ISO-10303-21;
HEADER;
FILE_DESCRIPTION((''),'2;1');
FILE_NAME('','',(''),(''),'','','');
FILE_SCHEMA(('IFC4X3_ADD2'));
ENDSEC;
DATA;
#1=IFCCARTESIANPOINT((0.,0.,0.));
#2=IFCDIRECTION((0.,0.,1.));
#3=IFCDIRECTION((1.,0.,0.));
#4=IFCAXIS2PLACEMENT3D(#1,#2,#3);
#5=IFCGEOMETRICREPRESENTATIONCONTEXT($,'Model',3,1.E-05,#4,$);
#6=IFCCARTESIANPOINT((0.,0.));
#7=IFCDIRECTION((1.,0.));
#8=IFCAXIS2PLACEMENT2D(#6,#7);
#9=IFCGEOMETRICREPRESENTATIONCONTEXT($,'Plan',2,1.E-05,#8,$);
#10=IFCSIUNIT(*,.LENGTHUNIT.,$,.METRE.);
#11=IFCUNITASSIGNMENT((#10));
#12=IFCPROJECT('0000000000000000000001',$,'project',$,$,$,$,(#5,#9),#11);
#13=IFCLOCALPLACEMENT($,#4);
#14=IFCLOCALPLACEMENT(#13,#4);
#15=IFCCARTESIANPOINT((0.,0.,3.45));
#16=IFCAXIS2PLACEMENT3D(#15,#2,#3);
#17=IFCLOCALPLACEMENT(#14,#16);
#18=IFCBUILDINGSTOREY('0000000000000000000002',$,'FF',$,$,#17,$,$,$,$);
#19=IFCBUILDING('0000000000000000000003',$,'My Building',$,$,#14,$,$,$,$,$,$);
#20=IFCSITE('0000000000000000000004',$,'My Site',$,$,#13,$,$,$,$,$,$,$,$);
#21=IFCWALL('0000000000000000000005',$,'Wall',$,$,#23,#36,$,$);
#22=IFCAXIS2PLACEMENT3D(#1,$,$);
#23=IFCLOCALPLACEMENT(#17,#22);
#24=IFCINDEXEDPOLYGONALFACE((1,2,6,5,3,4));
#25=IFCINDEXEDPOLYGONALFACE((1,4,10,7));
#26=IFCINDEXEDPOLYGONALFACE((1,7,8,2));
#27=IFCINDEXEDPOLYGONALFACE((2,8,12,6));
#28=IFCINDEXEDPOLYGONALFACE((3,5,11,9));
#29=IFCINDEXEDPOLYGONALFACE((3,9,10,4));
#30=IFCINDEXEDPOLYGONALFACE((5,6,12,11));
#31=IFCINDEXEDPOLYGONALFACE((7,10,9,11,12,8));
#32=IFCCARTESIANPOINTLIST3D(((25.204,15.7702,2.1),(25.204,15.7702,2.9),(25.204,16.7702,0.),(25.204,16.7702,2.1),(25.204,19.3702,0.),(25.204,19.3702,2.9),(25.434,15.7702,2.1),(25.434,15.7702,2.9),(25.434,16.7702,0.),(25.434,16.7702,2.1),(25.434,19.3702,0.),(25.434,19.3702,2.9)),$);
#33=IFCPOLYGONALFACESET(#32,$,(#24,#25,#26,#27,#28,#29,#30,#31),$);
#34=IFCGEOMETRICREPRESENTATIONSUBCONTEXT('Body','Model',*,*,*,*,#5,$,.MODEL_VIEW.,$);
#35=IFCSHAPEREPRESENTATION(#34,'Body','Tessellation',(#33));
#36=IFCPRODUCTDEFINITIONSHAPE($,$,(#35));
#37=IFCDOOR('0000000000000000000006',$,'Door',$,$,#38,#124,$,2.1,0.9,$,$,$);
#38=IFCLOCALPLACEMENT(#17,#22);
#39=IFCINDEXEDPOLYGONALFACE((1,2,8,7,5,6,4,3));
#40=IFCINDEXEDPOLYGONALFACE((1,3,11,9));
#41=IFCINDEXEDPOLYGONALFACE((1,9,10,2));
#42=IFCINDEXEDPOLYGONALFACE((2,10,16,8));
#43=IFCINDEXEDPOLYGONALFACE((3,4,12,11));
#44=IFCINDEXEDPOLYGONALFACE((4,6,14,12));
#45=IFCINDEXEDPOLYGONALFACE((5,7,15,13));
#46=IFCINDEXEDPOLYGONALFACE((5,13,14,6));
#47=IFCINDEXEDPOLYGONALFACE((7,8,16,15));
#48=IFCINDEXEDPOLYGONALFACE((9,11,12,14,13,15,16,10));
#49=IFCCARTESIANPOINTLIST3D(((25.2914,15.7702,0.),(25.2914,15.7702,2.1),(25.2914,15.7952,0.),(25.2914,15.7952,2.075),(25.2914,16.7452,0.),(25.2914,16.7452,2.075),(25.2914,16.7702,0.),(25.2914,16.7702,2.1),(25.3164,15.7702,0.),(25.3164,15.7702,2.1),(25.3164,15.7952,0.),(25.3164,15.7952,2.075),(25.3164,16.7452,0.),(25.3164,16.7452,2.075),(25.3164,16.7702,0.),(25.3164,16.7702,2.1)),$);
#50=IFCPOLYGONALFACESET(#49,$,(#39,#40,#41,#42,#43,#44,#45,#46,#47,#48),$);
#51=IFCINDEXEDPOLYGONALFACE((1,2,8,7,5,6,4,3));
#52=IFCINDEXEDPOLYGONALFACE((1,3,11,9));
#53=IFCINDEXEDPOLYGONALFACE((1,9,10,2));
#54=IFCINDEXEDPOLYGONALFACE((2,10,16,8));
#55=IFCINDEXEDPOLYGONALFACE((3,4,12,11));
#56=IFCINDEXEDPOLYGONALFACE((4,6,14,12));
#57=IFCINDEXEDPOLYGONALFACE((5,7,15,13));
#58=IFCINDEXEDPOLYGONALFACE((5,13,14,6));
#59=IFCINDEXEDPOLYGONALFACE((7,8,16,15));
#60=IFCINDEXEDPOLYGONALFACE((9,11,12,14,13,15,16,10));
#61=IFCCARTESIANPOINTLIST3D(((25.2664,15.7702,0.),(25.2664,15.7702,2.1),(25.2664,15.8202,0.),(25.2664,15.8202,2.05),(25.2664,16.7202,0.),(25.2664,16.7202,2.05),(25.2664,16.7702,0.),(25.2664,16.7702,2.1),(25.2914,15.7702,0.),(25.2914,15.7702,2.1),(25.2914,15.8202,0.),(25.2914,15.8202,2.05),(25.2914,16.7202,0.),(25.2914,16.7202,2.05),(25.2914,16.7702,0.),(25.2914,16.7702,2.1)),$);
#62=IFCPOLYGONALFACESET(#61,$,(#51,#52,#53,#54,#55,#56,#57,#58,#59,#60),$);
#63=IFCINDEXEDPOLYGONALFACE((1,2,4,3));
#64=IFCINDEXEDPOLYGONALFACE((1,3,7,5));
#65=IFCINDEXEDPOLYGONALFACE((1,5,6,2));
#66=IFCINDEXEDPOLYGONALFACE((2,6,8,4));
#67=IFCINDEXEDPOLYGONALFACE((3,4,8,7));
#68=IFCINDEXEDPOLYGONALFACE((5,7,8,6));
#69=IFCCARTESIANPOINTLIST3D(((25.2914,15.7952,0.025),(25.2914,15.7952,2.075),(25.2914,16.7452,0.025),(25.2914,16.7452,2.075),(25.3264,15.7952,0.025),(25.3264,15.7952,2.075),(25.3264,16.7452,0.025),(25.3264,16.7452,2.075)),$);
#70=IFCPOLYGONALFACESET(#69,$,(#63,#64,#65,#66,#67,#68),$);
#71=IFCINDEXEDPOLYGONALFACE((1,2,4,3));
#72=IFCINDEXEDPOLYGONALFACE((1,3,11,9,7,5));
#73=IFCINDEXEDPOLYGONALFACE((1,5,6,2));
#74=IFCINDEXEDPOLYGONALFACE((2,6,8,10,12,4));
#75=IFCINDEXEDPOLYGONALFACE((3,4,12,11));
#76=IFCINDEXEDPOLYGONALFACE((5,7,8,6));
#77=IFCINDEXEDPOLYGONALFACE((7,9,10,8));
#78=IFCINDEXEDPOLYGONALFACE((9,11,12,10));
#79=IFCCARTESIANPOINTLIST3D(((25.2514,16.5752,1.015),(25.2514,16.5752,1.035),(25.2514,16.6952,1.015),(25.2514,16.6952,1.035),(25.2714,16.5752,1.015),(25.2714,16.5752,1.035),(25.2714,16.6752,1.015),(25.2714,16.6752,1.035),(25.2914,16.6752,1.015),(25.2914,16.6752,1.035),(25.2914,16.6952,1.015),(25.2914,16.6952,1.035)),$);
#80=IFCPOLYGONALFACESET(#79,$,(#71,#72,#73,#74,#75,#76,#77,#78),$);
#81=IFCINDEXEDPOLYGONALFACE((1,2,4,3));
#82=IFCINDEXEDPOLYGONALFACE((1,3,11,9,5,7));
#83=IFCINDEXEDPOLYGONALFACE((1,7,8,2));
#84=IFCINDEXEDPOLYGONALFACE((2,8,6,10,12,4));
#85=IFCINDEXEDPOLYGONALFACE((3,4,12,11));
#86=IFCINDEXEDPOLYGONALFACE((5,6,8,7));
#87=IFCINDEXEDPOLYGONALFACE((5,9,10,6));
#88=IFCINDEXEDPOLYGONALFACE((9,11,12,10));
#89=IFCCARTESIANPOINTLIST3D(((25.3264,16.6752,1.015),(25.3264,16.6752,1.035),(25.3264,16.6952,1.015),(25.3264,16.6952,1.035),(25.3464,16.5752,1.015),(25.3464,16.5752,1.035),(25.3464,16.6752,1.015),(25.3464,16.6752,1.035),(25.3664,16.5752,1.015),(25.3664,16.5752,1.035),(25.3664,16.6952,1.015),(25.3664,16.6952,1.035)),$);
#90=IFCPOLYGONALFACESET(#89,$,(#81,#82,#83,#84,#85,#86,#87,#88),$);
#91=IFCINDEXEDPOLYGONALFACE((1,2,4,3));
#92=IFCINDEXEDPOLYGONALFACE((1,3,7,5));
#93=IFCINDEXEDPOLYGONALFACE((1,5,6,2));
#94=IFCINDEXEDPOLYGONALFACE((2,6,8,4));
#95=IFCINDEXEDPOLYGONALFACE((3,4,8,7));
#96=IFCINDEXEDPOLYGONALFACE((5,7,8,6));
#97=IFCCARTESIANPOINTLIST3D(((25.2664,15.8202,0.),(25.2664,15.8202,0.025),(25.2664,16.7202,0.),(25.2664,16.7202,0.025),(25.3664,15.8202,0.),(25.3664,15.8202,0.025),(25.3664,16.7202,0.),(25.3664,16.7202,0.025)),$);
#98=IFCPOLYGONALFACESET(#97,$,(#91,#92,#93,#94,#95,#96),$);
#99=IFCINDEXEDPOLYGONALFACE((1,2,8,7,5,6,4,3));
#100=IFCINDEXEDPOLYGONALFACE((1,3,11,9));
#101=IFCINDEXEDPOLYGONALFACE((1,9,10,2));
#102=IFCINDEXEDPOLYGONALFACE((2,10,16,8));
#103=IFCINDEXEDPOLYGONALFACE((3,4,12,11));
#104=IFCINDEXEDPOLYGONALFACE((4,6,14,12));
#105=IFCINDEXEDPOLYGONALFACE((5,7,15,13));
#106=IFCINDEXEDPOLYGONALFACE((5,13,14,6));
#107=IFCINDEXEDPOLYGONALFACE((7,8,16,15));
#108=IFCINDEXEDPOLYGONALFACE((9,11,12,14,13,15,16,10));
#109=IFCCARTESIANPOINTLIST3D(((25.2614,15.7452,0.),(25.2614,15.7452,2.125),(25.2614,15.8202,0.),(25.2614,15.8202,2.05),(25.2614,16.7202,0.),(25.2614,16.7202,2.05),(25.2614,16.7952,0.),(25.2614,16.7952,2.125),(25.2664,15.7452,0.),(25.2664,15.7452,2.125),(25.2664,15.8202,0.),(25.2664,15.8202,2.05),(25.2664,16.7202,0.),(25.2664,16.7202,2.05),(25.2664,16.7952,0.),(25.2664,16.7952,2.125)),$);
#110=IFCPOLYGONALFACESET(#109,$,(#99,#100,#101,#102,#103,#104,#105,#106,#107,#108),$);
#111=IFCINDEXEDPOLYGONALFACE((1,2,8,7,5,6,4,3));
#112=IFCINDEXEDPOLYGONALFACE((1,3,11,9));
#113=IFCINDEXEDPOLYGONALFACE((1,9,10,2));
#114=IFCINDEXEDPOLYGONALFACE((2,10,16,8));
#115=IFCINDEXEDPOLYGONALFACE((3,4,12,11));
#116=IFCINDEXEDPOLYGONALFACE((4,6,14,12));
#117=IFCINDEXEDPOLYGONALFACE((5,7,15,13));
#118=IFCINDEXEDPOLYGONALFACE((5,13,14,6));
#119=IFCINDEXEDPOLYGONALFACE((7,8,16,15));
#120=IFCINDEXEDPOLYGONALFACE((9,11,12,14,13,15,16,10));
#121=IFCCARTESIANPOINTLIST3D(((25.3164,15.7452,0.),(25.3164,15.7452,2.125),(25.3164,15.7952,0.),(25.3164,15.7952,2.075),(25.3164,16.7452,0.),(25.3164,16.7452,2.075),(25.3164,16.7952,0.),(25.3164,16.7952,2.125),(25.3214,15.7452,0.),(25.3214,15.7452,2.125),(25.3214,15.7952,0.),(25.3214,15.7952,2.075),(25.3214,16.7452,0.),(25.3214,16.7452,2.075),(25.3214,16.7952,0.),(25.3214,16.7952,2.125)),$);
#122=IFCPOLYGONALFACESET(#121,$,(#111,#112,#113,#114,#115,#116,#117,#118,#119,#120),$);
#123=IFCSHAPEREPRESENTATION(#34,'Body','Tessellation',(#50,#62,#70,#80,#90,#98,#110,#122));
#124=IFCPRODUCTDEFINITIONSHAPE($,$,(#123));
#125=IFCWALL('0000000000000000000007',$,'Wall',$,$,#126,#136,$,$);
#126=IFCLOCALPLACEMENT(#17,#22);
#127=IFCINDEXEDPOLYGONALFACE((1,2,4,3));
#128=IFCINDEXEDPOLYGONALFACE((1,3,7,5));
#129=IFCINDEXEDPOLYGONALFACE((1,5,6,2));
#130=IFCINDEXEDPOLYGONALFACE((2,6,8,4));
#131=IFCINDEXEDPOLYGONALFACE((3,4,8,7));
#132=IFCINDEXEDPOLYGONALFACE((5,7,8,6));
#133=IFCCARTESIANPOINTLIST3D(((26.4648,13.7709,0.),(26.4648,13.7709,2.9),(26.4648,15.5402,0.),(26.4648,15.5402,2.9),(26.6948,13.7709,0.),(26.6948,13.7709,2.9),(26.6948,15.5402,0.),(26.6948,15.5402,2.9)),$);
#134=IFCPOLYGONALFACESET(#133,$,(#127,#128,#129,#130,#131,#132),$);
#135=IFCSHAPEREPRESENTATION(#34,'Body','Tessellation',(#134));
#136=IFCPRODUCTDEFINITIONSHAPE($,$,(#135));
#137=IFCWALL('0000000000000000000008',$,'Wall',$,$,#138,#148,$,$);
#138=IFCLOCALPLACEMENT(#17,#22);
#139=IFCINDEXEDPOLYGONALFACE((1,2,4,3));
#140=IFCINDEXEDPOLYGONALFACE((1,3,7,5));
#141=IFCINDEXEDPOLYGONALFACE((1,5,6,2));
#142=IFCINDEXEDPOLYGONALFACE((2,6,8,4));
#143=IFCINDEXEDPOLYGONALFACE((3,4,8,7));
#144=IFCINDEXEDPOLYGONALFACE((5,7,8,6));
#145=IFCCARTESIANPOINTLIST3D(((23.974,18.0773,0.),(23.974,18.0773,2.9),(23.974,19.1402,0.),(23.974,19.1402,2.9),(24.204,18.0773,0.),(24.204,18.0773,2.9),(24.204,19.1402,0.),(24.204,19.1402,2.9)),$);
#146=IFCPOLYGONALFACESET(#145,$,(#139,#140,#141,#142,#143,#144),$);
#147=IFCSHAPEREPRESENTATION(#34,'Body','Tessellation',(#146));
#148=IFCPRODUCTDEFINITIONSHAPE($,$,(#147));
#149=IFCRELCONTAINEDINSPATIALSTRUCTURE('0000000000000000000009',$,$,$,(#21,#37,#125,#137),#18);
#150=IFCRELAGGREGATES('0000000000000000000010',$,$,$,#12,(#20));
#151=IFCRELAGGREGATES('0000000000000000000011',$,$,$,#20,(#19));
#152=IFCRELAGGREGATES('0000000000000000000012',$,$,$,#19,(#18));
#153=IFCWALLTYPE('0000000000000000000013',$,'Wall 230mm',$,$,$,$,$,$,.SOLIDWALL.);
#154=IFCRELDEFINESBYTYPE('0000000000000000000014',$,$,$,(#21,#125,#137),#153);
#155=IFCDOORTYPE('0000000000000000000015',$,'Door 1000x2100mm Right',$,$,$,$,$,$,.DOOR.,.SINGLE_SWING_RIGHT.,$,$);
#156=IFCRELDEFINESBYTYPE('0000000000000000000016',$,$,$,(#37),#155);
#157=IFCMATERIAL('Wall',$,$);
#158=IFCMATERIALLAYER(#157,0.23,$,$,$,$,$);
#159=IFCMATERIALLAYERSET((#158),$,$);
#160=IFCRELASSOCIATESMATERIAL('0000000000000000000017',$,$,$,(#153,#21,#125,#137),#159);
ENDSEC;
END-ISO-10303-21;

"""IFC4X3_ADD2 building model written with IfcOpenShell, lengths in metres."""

from ifc_helpers import new_model, entity, si_unit, frame, origin_with_axes, origin_2d_with_axis, place, context, subcontext, project, spatial, line, indexed_curve, outline, extrude, shape, source, transform, mapped, material, layer, layer_set, layer_usage, type_object, type_shapes, element, fill, save


model = new_model("IFC4X3_ADD2")

# Units and contexts
model_context = context("Model", 3, precision=1e-05, world=origin_with_axes())
plan_context = context("Plan", 2, precision=1e-05, world=origin_2d_with_axis())
body_context_1 = subcontext(model_context, "Body", "Model", "MODEL_VIEW")
body_context_2 = subcontext(plan_context, "Body", "Plan", "PLAN_VIEW")
ifc_project = project(units=[si_unit("LENGTHUNIT", "METRE")], contexts=[model_context, plan_context])

# Site, building, storey
site_placement = place(None, origin_with_axes())
site = spatial("IfcSite", under=ifc_project, at=site_placement, Name="My Site")
building_placement = place(site_placement, origin_with_axes())
building = spatial("IfcBuilding", under=site, at=building_placement, Name="My Building")
storey_placement = place(building_placement, frame((0.0, 0.0, 3.45), z_axis=(0.0, 0.0, 1.0), x_axis=(1.0, 0.0, 0.0)))
storey = spatial("IfcBuildingStorey", under=building, at=storey_placement, Name="FF")

# Shared definitions
ifc_material_1 = material(Name="Wall")
ifc_layer_1 = layer(ifc_material_1, 0.23)
ifc_layer_set_1 = layer_set([ifc_layer_1])
wall_type_1 = type_object("IfcWallType", Name="Wall 230mm", PredefinedType="SOLIDWALL", material=ifc_layer_set_1)

# Wall, opening, door
ifc_layer_usage_1 = layer_usage(ifc_layer_set_1, "AXIS2", "POSITIVE", 0.0)
wall_1_placement = place(storey_placement, frame((25.434, 15.7702, 0.0), z_axis=(0.0, 0.0, 1.0), x_axis=(0.000001, 1.0, 0.0)))
wall_1 = element("IfcWall", 1, at=wall_1_placement, inside=storey, type_object=wall_type_1, material=ifc_layer_usage_1, Name="Wall", context=body_context_1, shape_type="SweptSolid", body=[
    extrude(outline(indexed_curve([(0.0, 0.0), (0.0, 0.23), (3.6, 0.23), (3.6, 0.0), (0.0, 0.0)], self_intersect=False)), origin_with_axes(), (0.0, 0.0, 1.0), 2.9),
])
shared_shape_1 = source(origin_with_axes(), body_context_1, "Body", "SweptSolid", [
    extrude(outline(indexed_curve([(0.0, 0.0), (1.0, 0.0), (1.0, 2.1), (0.0, 2.1)], segments=[line(1, 2, 3, 4, 1)])), frame((0.0, -0.6, 0.0), z_axis=(0.0, -1.0, 0.0), x_axis=(1.0, 0.0, 0.0)), (0.0, 0.0, -1.0), 1.2),
])
opening_1_placement = place(wall_1_placement, frame((1.0, 0.1676, 0.0), z_axis=(0.0, 0.0, 1.0), x_axis=(-1.0, 0.0, 0.0)))
opening_1 = element("IfcOpeningElement", 2, at=opening_1_placement, cuts=wall_1, PredefinedType="OPENING", context=body_context_1, shape_type="MappedRepresentation", body=[
    mapped(shared_shape_1, transform((0.0, 0.0, 0.0), x_axis=(1.0, 0.0, 0.0), y_axis=(0.0, 1.0, 0.0), z_axis=(0.0, 0.0, 1.0), scale=1.0)),
])
door_type_1 = type_object("IfcDoorType", Name="Door 1000x2100mm Right", OperationType="SINGLE_SWING_RIGHT", PredefinedType="DOOR")
shared_shape_2 = source(origin_with_axes(), body_context_1, "Body", "SweptSolid", [
    extrude(outline(indexed_curve([(0.0, 0.0), (0.0, 2.1), (1.0, 2.1), (1.0, 0.0), (0.975, 0.0), (0.975, 2.075), (0.025, 2.075), (0.025, 0.0)], segments=[line(1, 2, 3, 4, 5, 6, 7, 8, 1)])), frame((0.0, 0.025, 0.0), z_axis=(0.0, -1.0, 0.0), x_axis=(1.0, 0.0, 0.0)), (0.0, 0.0, -1.0), 0.025),
    extrude(outline(indexed_curve([(0.0, 0.0), (0.0, 2.1), (1.0, 2.1), (1.0, 0.0), (0.95, 0.0), (0.95, 2.05), (0.05, 2.05), (0.05, 0.0)], segments=[line(1, 2, 3, 4, 5, 6, 7, 8, 1)])), frame((0.0, 0.0, 0.0), z_axis=(0.0, -1.0, 0.0), x_axis=(1.0, 0.0, 0.0)), (0.0, 0.0, -1.0), 0.025),
    extrude(outline(indexed_curve([(0.0, 0.0), (0.95, 0.0), (0.95, 0.035), (0.0, 0.035)], segments=[line(1, 2, 3, 4, 1)])), frame((0.025, 0.025, 0.025), z_axis=(0.0, 0.0, 1.0), x_axis=(1.0, 0.0, 0.0)), (0.0, 0.0, 1.0), 2.05),
    extrude(outline(indexed_curve([(0.0, 0.0), (0.0, -0.04), (0.12, -0.04), (0.12, -0.02), (0.02, -0.02), (0.02, 0.0)], segments=[line(1, 2, 3, 4, 5, 6, 1)])), frame((0.075, 0.025, 1.015), z_axis=(0.0, 0.0, 1.0), x_axis=(1.0, 0.0, 0.0)), (0.0, 0.0, 1.0), 0.02),
    extrude(outline(indexed_curve([(0.0, 0.0), (0.0, 0.04), (0.12, 0.04), (0.12, 0.02), (0.02, 0.02), (0.02, 0.0)], segments=[line(1, 2, 3, 4, 5, 6, 1)])), frame((0.075, 0.06, 1.015), z_axis=(0.0, 0.0, 1.0), x_axis=(1.0, 0.0, 0.0)), (0.0, 0.0, 1.0), 0.02),
    extrude(outline(indexed_curve([(0.0, 0.0), (0.9, 0.0), (0.9, 0.1), (0.0, 0.1)], segments=[line(1, 2, 3, 4, 1)])), frame((0.05, 0.0, 0.0), z_axis=(0.0, 0.0, 1.0), x_axis=(1.0, 0.0, 0.0)), (0.0, 0.0, 1.0), 0.025),
    extrude(outline(indexed_curve([(0.0, 0.0), (0.0, 2.125), (1.05, 2.125), (1.05, 0.0), (0.975, 0.0), (0.975, 2.05), (0.075, 2.05), (0.075, 0.0)], segments=[line(1, 2, 3, 4, 5, 6, 7, 8, 1)])), frame((-0.025, -0.005, 0.0), z_axis=(0.0, -1.0, 0.0), x_axis=(1.0, 0.0, 0.0)), (0.0, 0.0, -1.0), 0.005),
    extrude(outline(indexed_curve([(0.0, 0.0), (0.0, 2.125), (1.05, 2.125), (1.05, 0.0), (1.0, 0.0), (1.0, 2.075), (0.05, 2.075), (0.05, 0.0)], segments=[line(1, 2, 3, 4, 5, 6, 7, 8, 1)])), frame((-0.025, 0.05, 0.0), z_axis=(0.0, -1.0, 0.0), x_axis=(1.0, 0.0, 0.0)), (0.0, 0.0, -1.0), 0.005),
])
shared_shape_3 = source(origin_with_axes(), body_context_2, "Body", "Curve2D", [
    entity("IfcIndexedPolyCurve", entity("IfcCartesianPointList2D", [[0.0, 0.0], [0.0, 0.05], [0.025, 0.05], [0.025, 0.025], [0.05, 0.025], [0.05, 0.0]]), [entity("IfcLineIndex", [1, 2, 3, 4, 5, 6, 1])]),
    entity("IfcIndexedPolyCurve", entity("IfcCartesianPointList2D", [[1.0, 0.0], [1.0, 0.05], [0.975, 0.05], [0.975, 0.025], [0.95, 0.025], [0.95, 0.0]]), [entity("IfcLineIndex", [1, 2, 3, 4, 5, 6, 1])]),
    entity("IfcTrimmedCurve", entity("IfcEllipse", entity("IfcAxis2Placement2D", entity("IfcCartesianPoint", [0.94, 0.05]), entity("IfcDirection", [1.0, 0.0])), 0.915, 0.95), [entity("IfcCartesianPoint", [0.94, 1.0])], [entity("IfcCartesianPoint", [0.025, 0.05])], True, "CARTESIAN"),
    entity("IfcIndexedPolyCurve", entity("IfcCartesianPointList2D", [[0.975, 0.05], [0.94, 0.05], [0.94, 1.0], [0.975, 1.0]]), [entity("IfcLineIndex", [1, 2, 3, 4, 1])]),
])
type_shapes(door_type_1, [shared_shape_2, shared_shape_3])
door_1_placement = place(opening_1_placement, origin_with_axes())
door_1 = element("IfcDoor", 3, at=door_1_placement, inside=storey, type_object=door_type_1, Name="Door", OverallHeight=2.1, OverallWidth=0.9, shapes=[
    shape(body_context_1, "Body", "MappedRepresentation", [mapped(shared_shape_2, transform((0.0, 0.0, 0.0), x_axis=(1.0, 0.0, 0.0), y_axis=(0.0, 1.0, 0.0), z_axis=(0.0, 0.0, 1.0), scale=1.0))]),
    shape(body_context_2, "Body", "MappedRepresentation", [mapped(shared_shape_3, transform((0.0, 0.0, 0.0), x_axis=(1.0, 0.0, 0.0), y_axis=(0.0, 1.0, 0.0), z_axis=(0.0, 0.0, 1.0), scale=1.0))]),
])
fill(opening_1, door_1)

# Walls
ifc_layer_usage_2 = layer_usage(ifc_layer_set_1, "AXIS2", "POSITIVE", 0.0)
wall_2_placement = place(storey_placement, frame((26.6948, 13.7709, 0.0), z_axis=(0.0, 0.0, 1.0), x_axis=(0.000001, 1.0, 0.0)))
element("IfcWall", 4, at=wall_2_placement, inside=storey, type_object=wall_type_1, material=ifc_layer_usage_2, Name="Wall", context=body_context_1, shape_type="SweptSolid", body=[
    extrude(outline(indexed_curve([(0.0, 0.0), (0.0, 0.23), (1.7693, 0.23), (1.7693, 0.0), (0.0, 0.0)], self_intersect=False)), origin_with_axes(), (0.0, 0.0, 1.0), 2.9),
])
ifc_layer_usage_3 = layer_usage(ifc_layer_set_1, "AXIS2", "POSITIVE", 0.0)
wall_3_placement = place(storey_placement, frame((24.204, 18.0773, 0.0), z_axis=(0.0, 0.0, 1.0), x_axis=(0.000001, 1.0, 0.0)))
element("IfcWall", 5, at=wall_3_placement, inside=storey, type_object=wall_type_1, material=ifc_layer_usage_3, Name="Wall", context=body_context_1, shape_type="SweptSolid", body=[
    extrude(outline(indexed_curve([(0.0, 0.0), (0.0, 0.23), (1.0629, 0.23), (1.0629, 0.0), (0.0, 0.0)], self_intersect=False)), origin_with_axes(), (0.0, 0.0, 1.0), 2.9),
])

save(model, "model.ifc")
